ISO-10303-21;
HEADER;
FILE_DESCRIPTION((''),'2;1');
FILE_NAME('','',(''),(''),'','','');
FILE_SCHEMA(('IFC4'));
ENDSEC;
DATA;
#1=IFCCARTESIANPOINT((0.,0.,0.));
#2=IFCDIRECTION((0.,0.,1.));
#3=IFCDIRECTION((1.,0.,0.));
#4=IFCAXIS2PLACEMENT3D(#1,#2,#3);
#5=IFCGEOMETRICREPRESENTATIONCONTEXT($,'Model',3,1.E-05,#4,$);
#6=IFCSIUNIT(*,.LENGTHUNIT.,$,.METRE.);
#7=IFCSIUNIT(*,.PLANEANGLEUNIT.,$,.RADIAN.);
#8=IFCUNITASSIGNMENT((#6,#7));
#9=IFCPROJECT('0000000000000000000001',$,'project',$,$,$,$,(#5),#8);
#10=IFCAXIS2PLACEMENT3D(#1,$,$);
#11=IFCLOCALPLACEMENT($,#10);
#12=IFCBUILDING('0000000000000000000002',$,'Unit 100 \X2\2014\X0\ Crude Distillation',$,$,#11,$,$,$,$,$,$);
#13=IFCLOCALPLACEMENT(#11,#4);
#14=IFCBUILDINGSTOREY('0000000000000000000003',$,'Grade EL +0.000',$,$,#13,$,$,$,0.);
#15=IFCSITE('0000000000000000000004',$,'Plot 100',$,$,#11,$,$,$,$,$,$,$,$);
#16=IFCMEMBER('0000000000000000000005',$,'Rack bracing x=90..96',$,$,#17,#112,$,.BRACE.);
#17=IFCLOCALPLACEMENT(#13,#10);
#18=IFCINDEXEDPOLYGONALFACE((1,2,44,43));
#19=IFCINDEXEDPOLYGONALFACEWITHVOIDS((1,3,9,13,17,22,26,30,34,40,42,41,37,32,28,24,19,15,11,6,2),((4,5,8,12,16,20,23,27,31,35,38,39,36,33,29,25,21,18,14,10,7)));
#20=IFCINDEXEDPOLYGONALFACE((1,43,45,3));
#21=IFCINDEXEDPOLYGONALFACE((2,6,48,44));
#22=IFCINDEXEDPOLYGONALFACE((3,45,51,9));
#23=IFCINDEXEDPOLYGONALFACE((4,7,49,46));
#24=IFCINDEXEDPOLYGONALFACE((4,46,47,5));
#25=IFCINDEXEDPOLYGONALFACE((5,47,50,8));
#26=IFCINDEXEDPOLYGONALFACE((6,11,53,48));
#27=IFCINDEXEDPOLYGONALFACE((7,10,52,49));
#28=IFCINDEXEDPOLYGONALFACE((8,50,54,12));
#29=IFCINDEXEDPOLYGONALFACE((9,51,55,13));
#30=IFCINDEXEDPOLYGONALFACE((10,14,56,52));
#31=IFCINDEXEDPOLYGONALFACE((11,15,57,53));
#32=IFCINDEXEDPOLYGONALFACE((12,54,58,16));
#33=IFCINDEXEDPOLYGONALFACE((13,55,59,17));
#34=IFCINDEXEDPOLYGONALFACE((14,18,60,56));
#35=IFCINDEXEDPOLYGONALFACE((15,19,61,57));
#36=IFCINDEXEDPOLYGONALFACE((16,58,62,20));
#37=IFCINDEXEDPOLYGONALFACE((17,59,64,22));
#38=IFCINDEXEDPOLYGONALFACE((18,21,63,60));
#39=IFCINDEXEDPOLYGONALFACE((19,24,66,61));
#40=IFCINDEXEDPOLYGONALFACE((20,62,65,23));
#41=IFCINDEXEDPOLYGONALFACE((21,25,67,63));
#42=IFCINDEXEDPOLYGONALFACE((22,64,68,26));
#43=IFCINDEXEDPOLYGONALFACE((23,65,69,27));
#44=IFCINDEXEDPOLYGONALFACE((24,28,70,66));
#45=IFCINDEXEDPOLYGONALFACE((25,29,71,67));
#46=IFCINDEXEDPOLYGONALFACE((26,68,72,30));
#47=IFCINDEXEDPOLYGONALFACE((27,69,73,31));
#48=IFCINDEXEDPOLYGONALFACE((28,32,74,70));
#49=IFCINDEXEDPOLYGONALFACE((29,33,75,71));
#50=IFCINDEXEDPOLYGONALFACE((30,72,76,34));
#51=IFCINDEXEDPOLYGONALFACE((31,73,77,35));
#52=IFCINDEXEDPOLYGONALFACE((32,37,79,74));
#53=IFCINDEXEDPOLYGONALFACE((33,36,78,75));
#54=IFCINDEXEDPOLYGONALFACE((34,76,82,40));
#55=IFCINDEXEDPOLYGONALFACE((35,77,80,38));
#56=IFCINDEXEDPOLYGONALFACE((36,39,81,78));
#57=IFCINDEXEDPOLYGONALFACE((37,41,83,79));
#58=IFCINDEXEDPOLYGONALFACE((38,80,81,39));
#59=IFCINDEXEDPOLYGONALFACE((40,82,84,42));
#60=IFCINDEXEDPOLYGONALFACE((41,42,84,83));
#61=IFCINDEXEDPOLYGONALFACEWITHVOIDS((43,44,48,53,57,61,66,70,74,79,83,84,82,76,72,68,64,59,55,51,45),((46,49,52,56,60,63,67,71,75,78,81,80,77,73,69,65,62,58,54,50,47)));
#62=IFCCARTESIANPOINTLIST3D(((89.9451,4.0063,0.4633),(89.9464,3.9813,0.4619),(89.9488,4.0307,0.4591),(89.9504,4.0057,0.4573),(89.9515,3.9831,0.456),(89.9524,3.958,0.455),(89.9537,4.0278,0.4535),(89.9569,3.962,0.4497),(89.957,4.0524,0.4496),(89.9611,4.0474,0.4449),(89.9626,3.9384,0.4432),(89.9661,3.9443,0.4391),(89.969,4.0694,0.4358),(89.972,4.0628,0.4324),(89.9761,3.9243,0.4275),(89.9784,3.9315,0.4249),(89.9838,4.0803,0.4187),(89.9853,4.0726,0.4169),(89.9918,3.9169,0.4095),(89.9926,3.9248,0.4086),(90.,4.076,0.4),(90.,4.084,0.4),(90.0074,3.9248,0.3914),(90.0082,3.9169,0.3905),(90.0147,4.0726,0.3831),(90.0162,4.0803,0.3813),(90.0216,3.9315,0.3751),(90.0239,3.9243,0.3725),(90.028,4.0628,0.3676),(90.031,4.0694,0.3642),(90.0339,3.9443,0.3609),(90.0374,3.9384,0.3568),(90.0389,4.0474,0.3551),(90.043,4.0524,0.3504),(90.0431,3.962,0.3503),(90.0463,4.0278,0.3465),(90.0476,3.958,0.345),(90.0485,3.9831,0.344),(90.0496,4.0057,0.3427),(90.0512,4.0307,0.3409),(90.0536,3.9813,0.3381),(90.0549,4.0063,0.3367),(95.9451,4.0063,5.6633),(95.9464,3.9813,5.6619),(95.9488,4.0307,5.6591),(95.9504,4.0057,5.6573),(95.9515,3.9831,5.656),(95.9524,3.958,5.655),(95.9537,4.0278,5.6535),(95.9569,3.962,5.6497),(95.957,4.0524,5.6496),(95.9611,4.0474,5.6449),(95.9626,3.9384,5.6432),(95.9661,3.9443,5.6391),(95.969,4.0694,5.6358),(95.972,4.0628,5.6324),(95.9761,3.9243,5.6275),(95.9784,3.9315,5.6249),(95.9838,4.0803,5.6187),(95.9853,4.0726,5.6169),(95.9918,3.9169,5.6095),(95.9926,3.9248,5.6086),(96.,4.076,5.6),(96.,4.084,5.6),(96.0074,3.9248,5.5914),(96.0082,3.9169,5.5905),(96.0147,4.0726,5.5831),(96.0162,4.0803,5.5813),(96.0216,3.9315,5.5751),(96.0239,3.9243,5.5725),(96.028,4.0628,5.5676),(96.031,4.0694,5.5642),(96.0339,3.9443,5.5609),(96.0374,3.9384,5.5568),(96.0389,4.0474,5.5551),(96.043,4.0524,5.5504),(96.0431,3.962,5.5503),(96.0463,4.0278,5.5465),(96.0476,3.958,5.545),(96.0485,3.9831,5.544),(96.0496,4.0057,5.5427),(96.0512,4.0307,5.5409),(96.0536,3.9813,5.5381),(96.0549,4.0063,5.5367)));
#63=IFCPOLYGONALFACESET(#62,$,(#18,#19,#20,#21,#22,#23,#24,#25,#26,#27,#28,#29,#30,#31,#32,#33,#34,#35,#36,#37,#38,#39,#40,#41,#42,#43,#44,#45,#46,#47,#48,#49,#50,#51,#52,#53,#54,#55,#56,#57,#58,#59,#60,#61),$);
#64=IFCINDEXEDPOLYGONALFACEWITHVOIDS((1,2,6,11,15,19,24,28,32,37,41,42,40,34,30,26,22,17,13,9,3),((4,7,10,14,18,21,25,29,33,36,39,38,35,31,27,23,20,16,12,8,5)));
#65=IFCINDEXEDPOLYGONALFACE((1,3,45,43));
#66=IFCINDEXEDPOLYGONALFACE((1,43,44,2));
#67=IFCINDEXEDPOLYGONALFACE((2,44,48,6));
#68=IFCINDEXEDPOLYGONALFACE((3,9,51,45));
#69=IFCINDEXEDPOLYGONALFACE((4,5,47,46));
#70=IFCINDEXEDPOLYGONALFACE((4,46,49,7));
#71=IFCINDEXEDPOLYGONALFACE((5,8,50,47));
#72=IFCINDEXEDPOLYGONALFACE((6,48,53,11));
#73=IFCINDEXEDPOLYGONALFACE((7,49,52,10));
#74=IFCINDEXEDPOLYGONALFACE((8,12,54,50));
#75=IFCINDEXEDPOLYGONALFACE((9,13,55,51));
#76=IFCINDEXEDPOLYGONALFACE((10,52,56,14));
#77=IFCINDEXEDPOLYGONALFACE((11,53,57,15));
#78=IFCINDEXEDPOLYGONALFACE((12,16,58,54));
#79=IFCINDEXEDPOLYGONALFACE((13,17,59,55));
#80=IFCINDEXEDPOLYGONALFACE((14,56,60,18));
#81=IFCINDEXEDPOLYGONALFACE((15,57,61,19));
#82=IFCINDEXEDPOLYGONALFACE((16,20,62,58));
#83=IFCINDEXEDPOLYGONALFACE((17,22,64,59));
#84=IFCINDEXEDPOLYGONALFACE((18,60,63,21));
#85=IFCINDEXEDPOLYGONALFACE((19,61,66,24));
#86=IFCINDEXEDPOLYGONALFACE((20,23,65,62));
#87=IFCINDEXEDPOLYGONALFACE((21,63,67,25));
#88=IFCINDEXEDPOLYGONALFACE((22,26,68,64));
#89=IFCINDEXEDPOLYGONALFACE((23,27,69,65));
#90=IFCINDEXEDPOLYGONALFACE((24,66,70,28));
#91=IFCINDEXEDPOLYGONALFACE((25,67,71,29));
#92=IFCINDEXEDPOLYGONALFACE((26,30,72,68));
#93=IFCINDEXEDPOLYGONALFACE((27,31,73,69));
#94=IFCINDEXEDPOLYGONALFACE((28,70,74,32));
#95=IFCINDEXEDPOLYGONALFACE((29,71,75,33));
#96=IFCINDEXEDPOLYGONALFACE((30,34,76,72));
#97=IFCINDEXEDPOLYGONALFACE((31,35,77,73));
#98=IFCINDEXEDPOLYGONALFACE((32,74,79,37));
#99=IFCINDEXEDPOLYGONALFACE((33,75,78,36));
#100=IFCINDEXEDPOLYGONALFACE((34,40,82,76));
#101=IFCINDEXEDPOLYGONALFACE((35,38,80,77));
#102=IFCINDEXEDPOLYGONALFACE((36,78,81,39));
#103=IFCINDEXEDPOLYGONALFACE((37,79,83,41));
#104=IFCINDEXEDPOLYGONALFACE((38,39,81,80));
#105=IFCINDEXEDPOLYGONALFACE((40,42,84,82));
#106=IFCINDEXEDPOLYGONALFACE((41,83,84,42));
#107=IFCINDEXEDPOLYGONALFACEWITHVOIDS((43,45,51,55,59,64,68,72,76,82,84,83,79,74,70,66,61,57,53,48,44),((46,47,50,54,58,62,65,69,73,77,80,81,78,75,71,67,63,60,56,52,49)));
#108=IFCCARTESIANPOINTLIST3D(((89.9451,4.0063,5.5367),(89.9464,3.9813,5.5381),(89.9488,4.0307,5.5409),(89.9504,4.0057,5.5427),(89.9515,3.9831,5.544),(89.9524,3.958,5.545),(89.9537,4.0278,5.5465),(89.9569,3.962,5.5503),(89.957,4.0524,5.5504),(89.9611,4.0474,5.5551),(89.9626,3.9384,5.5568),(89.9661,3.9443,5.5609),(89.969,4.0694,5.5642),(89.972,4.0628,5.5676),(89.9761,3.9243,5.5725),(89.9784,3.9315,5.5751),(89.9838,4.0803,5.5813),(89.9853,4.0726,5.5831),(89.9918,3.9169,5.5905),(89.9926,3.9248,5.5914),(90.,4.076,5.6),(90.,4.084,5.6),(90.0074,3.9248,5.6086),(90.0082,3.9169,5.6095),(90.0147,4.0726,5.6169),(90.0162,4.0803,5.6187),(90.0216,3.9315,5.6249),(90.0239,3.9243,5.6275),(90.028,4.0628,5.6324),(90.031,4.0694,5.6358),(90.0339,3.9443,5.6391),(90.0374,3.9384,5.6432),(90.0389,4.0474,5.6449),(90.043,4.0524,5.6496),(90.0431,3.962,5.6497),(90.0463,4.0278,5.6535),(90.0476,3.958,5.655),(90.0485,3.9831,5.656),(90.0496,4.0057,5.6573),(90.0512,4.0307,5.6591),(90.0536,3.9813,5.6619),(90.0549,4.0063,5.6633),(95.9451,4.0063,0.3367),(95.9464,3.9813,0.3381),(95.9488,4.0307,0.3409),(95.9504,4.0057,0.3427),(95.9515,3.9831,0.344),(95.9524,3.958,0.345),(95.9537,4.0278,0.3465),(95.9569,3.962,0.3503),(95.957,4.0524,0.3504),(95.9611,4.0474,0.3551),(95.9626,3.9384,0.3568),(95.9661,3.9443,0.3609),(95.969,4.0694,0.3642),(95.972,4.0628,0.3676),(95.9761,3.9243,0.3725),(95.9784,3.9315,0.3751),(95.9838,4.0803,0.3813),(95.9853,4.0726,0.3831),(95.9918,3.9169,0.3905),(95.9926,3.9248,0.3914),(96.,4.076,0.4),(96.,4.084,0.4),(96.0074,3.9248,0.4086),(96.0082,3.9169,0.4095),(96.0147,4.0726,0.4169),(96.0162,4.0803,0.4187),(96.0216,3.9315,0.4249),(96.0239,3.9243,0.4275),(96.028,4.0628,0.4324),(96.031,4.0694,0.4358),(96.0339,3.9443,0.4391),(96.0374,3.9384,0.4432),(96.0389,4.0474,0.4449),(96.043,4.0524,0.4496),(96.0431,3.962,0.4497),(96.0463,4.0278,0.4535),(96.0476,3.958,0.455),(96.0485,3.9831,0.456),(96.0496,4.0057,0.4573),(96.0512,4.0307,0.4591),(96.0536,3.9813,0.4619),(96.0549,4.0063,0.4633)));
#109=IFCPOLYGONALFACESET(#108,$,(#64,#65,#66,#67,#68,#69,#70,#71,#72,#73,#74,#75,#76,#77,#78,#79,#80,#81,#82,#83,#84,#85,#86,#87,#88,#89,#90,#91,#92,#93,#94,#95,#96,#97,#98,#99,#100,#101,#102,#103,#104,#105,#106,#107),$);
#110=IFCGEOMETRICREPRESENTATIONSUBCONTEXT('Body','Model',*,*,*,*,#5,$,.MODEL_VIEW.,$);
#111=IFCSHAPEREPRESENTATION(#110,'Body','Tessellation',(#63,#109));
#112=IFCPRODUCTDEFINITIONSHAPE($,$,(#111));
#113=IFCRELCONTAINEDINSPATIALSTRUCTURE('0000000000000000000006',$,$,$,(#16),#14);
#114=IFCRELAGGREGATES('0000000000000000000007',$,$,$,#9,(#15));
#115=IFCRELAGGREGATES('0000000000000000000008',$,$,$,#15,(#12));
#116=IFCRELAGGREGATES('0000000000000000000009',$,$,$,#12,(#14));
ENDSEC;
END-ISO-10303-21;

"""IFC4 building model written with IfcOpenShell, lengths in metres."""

from ifc_helpers import new_model, si_unit, frame, origin, origin_with_axes, origin_2d, place, context, subcontext, project, spatial, hollow_circle, extrude, element, save


model = new_model("IFC4")

# Units and contexts
model_context = context("Model", 3, precision=1e-05, world=origin_with_axes())
body_context = subcontext(model_context, "Body", "Model", "MODEL_VIEW")
ifc_project = project(units=[si_unit("LENGTHUNIT", "METRE"), si_unit("PLANEANGLEUNIT", "RADIAN")], contexts=[model_context])

# Site, building, storey
placement = place(None, origin())
site = spatial("IfcSite", under=ifc_project, at=placement, Name="Plot 100")
building = spatial("IfcBuilding", under=site, at=placement, Name="Unit 100 — Crude Distillation")
storey_placement = place(placement, origin_with_axes())
storey = spatial("IfcBuildingStorey", under=building, at=storey_placement, Name="Grade EL +0.000", Elevation=0.0)

# Member
member_1_placement = place(storey_placement, origin_with_axes())
element("IfcMember", 1, at=member_1_placement, inside=storey, Name="Rack bracing x=90..96", PredefinedType="BRACE", context=body_context, shape_type="SweptSolid", body=[
    extrude(hollow_circle(Radius=0.084, WallThickness=0.008, at=origin_2d()), frame((90.0, 4.0, 0.4), z_axis=(0.755689, 0.0, 0.654931), x_axis=(0.0, 1.0, 0.0)), (0.0, 0.0, 1.0), 7.9398),
    extrude(hollow_circle(Radius=0.084, WallThickness=0.008, at=origin_2d()), frame((90.0, 4.0, 5.6), z_axis=(0.755689, 0.0, -0.654931), x_axis=(0.0, 1.0, 0.0)), (0.0, 0.0, 1.0), 7.9398),
])

save(model, "model.ifc")
